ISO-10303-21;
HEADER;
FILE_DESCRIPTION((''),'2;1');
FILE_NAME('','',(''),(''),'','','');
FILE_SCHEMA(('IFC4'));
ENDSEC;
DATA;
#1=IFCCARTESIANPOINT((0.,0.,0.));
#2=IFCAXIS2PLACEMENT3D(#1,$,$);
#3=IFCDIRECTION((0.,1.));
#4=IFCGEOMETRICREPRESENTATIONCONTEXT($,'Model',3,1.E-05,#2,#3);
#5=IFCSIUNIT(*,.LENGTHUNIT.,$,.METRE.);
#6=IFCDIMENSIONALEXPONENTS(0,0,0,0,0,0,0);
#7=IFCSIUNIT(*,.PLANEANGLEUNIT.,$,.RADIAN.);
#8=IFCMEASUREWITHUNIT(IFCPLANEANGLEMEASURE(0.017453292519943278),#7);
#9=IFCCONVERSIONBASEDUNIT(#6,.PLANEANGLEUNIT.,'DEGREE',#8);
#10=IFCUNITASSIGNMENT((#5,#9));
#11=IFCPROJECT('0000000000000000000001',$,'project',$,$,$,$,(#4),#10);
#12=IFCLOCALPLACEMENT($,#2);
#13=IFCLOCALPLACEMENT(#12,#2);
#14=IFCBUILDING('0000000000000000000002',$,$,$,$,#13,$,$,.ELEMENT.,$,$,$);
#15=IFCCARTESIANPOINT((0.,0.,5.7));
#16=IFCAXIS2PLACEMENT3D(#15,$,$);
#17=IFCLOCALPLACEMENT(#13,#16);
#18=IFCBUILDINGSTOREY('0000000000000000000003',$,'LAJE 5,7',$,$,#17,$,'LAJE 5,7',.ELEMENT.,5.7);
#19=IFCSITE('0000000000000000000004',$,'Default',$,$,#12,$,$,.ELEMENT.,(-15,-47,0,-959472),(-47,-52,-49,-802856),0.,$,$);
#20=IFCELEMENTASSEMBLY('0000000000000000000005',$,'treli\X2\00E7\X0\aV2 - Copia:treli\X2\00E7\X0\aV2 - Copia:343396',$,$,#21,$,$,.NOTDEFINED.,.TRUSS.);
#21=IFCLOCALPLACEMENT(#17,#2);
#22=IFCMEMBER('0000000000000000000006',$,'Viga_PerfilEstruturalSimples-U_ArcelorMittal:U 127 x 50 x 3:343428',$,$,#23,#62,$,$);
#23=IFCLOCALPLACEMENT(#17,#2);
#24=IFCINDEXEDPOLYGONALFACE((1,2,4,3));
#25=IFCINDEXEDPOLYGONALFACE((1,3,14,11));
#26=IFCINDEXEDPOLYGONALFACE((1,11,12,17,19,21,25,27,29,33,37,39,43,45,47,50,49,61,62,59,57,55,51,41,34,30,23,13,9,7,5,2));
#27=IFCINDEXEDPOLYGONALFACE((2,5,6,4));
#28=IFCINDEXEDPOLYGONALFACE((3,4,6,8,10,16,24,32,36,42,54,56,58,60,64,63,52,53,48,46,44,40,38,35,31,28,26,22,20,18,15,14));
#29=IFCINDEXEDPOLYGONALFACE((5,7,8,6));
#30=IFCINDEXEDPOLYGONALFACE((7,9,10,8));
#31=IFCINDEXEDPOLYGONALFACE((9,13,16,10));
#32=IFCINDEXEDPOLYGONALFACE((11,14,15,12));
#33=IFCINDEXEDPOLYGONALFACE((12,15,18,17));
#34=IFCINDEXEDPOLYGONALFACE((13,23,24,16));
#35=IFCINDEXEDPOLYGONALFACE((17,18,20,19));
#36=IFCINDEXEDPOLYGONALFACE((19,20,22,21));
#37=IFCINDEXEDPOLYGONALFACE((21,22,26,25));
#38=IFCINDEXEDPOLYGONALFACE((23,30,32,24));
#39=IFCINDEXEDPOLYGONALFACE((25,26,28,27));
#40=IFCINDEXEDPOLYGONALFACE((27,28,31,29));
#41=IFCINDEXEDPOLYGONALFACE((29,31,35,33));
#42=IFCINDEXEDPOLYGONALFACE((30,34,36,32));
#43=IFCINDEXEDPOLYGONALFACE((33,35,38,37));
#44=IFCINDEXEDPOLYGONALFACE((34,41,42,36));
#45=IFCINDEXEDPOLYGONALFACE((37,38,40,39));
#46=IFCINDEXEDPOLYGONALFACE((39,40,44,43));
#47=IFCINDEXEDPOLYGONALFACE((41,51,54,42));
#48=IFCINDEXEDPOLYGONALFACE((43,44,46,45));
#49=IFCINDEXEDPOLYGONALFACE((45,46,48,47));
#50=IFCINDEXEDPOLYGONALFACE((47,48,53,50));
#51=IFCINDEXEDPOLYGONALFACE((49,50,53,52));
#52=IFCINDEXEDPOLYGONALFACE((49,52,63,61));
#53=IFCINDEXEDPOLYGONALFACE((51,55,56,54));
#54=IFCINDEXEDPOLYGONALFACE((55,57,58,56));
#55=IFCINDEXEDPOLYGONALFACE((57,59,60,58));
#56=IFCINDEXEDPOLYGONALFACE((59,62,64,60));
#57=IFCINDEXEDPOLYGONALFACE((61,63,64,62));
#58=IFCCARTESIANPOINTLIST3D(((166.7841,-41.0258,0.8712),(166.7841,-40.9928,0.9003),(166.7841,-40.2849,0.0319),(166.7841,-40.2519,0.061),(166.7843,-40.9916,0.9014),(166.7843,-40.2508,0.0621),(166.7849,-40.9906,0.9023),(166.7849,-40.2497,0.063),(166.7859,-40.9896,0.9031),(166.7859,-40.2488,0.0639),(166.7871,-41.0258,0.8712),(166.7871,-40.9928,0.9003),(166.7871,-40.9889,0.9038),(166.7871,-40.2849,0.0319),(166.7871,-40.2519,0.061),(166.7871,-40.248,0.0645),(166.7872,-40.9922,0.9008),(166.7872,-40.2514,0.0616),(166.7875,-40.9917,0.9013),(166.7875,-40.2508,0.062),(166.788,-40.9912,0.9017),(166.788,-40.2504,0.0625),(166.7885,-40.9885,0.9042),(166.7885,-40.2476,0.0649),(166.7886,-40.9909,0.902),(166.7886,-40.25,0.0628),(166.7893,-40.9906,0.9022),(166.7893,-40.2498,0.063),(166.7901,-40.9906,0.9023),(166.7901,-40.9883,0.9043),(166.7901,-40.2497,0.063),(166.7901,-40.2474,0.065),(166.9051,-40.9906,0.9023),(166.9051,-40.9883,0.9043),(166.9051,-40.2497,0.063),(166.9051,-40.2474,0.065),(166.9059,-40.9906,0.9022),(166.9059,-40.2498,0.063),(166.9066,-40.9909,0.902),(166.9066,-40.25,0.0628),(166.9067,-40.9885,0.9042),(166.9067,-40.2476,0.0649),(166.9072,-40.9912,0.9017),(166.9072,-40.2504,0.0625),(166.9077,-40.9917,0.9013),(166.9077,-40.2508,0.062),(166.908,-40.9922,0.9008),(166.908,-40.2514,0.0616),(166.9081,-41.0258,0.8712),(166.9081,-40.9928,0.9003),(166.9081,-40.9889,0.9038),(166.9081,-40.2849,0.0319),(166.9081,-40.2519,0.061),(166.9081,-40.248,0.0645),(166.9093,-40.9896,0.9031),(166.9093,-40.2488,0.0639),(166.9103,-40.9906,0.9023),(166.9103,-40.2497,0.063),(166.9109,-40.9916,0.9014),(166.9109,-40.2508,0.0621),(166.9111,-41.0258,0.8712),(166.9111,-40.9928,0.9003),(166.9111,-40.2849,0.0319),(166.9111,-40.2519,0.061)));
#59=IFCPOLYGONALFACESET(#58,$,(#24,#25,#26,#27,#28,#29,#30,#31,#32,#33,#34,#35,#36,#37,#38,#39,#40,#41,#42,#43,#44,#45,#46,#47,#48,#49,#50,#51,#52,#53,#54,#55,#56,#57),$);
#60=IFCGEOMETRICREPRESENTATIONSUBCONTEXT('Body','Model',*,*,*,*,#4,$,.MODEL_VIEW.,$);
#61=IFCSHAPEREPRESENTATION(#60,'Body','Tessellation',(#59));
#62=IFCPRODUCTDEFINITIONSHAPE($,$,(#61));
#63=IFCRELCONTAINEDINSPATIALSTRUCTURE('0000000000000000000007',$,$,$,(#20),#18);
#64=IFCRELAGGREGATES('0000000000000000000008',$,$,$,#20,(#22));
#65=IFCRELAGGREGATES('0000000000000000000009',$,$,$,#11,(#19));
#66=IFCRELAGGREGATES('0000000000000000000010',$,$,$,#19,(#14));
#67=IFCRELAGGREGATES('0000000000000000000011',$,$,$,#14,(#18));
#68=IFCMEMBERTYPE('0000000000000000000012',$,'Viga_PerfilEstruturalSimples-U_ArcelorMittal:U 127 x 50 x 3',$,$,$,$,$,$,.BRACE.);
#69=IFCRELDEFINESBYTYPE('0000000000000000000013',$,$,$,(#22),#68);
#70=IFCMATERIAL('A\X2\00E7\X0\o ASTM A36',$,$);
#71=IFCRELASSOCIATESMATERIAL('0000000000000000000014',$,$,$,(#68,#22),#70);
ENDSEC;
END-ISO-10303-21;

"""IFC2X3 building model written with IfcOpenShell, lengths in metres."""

from ifc_helpers import new_model, entity, si_unit, converted_unit, direction, frame, frame_2d, origin, place, context, subcontext, project, spatial, polyline, circle_curve, parameter, trimmed, segment, composite_curve, outline, extrude, source, transform, mapped, material, type_object, type_shapes, element, aggregate, save


model = new_model("IFC2X3")

# Units and contexts
model_context = context("Model", 3, precision=1e-05, world=origin(), true_north=direction((0.0, 1.0)))
body_context = subcontext(model_context, "Body", "Model", "MODEL_VIEW")
ifc_project = project(units=[si_unit("LENGTHUNIT", "METRE"), converted_unit("PLANEANGLEUNIT", "DEGREE", entity("IfcPlaneAngleMeasure", 0.017453292519943278), si_unit("PLANEANGLEUNIT", "RADIAN"), dimensions=[0, 0, 0, 0, 0, 0, 0])], contexts=[model_context])

# Site, building, storey
site_placement = place(None, origin())
site = spatial("IfcSite", under=ifc_project, at=site_placement, Name="Default", CompositionType="ELEMENT", RefLatitude=(-15, -47, 0, -959472), RefLongitude=(-47, -52, -49, -802856), RefElevation=0.0)
building_placement = place(site_placement, origin())
building = spatial("IfcBuilding", under=site, at=building_placement, CompositionType="ELEMENT")
storey_placement = place(building_placement, frame((0.0, 0.0, 5.7)))
storey = spatial("IfcBuildingStorey", under=building, at=storey_placement, Name="LAJE 5,7", LongName="LAJE 5,7", CompositionType="ELEMENT", Elevation=5.7)

# Element assembly
assembly_1_placement = place(storey_placement, origin())
assembly_1 = element("IfcElementAssembly", 1, at=assembly_1_placement, inside=storey, Name="treliçaV2 - Copia:treliçaV2 - Copia:343396", AssemblyPlace="NOTDEFINED", PredefinedType="TRUSS")
ifc_material = material(Name="Aço ASTM A36")

# Member
member_type_1 = type_object("IfcMemberType", Name="Viga_PerfilEstruturalSimples-U_ArcelorMittal:U 127 x 50 x 3", PredefinedType="BRACE", material=ifc_material)
shared_shape_1 = source(origin(), body_context, "Body", "SweptSolid", [
    extrude(outline(composite_curve([segment(polyline([(-0.0575, -0.0192), (0.0575, -0.0192)]), True, "CONTINUOUS"), segment(trimmed(circle_curve(frame_2d((0.0575, -0.0132), x_axis=(0.0, 1.0)), 0.006), [parameter(180.0)], [parameter(270.0)], True, "PARAMETER"), True, "CONTINUOUS"), segment(polyline([(0.0635, -0.0132), (0.0635, 0.0308)]), True, "CONTINUOUS"), segment(polyline([(0.0635, 0.0308), (0.0605, 0.0308)]), True, "CONTINUOUS"), segment(polyline([(0.0605, 0.0308), (0.0605, -0.0132)]), True, "CONTINUOUS"), segment(trimmed(circle_curve(frame_2d((0.0575, -0.0132), x_axis=(0.0, 1.0)), 0.003), [parameter(180.0)], [parameter(270.0)], True, "PARAMETER"), False, "CONTINUOUS"), segment(polyline([(0.0575, -0.0162), (-0.0575, -0.0162)]), True, "CONTINUOUS"), segment(trimmed(circle_curve(frame_2d((-0.0575, -0.0132), x_axis=(0.0, 1.0)), 0.003), [parameter(90.0)], [parameter(180.0)], True, "PARAMETER"), False, "CONTINUOUS"), segment(polyline([(-0.0605, -0.0132), (-0.0605, 0.0308)]), True, "CONTINUOUS"), segment(polyline([(-0.0605, 0.0308), (-0.0635, 0.0308)]), True, "CONTINUOUS"), segment(polyline([(-0.0635, 0.0308), (-0.0635, -0.0132)]), True, "CONTINUOUS"), segment(trimmed(circle_curve(frame_2d((-0.0575, -0.0132), x_axis=(0.0, 1.0)), 0.006), [parameter(90.0)], [parameter(180.0)], True, "PARAMETER"), True, "CONTINUOUS")], self_intersect=False)), frame((-0.5514, -0.0058, 0.0), z_axis=(1.0, 0.0, 0.0), x_axis=(0.0, 0.0, -1.0)), (0.0, 0.0, 1.0), 1.1195),
])
type_shapes(member_type_1, [shared_shape_1])
member_1_placement = place(assembly_1_placement, frame((166.8476, -40.6421, 0.4744), z_axis=(-1.0, 0.0, 0.0), x_axis=(0.0, 0.661783, -0.749695)))
member_1 = element("IfcMember", 2, at=member_1_placement, type_object=member_type_1, material=ifc_material, Name="Viga_PerfilEstruturalSimples-U_ArcelorMittal:U 127 x 50 x 3:343428", context=body_context, shape_type="MappedRepresentation", body=[
    mapped(shared_shape_1, transform((0.0, 0.0, 0.0), scale=1.0)),
])
aggregate(assembly_1, [member_1])

save(model, "model.ifc")
